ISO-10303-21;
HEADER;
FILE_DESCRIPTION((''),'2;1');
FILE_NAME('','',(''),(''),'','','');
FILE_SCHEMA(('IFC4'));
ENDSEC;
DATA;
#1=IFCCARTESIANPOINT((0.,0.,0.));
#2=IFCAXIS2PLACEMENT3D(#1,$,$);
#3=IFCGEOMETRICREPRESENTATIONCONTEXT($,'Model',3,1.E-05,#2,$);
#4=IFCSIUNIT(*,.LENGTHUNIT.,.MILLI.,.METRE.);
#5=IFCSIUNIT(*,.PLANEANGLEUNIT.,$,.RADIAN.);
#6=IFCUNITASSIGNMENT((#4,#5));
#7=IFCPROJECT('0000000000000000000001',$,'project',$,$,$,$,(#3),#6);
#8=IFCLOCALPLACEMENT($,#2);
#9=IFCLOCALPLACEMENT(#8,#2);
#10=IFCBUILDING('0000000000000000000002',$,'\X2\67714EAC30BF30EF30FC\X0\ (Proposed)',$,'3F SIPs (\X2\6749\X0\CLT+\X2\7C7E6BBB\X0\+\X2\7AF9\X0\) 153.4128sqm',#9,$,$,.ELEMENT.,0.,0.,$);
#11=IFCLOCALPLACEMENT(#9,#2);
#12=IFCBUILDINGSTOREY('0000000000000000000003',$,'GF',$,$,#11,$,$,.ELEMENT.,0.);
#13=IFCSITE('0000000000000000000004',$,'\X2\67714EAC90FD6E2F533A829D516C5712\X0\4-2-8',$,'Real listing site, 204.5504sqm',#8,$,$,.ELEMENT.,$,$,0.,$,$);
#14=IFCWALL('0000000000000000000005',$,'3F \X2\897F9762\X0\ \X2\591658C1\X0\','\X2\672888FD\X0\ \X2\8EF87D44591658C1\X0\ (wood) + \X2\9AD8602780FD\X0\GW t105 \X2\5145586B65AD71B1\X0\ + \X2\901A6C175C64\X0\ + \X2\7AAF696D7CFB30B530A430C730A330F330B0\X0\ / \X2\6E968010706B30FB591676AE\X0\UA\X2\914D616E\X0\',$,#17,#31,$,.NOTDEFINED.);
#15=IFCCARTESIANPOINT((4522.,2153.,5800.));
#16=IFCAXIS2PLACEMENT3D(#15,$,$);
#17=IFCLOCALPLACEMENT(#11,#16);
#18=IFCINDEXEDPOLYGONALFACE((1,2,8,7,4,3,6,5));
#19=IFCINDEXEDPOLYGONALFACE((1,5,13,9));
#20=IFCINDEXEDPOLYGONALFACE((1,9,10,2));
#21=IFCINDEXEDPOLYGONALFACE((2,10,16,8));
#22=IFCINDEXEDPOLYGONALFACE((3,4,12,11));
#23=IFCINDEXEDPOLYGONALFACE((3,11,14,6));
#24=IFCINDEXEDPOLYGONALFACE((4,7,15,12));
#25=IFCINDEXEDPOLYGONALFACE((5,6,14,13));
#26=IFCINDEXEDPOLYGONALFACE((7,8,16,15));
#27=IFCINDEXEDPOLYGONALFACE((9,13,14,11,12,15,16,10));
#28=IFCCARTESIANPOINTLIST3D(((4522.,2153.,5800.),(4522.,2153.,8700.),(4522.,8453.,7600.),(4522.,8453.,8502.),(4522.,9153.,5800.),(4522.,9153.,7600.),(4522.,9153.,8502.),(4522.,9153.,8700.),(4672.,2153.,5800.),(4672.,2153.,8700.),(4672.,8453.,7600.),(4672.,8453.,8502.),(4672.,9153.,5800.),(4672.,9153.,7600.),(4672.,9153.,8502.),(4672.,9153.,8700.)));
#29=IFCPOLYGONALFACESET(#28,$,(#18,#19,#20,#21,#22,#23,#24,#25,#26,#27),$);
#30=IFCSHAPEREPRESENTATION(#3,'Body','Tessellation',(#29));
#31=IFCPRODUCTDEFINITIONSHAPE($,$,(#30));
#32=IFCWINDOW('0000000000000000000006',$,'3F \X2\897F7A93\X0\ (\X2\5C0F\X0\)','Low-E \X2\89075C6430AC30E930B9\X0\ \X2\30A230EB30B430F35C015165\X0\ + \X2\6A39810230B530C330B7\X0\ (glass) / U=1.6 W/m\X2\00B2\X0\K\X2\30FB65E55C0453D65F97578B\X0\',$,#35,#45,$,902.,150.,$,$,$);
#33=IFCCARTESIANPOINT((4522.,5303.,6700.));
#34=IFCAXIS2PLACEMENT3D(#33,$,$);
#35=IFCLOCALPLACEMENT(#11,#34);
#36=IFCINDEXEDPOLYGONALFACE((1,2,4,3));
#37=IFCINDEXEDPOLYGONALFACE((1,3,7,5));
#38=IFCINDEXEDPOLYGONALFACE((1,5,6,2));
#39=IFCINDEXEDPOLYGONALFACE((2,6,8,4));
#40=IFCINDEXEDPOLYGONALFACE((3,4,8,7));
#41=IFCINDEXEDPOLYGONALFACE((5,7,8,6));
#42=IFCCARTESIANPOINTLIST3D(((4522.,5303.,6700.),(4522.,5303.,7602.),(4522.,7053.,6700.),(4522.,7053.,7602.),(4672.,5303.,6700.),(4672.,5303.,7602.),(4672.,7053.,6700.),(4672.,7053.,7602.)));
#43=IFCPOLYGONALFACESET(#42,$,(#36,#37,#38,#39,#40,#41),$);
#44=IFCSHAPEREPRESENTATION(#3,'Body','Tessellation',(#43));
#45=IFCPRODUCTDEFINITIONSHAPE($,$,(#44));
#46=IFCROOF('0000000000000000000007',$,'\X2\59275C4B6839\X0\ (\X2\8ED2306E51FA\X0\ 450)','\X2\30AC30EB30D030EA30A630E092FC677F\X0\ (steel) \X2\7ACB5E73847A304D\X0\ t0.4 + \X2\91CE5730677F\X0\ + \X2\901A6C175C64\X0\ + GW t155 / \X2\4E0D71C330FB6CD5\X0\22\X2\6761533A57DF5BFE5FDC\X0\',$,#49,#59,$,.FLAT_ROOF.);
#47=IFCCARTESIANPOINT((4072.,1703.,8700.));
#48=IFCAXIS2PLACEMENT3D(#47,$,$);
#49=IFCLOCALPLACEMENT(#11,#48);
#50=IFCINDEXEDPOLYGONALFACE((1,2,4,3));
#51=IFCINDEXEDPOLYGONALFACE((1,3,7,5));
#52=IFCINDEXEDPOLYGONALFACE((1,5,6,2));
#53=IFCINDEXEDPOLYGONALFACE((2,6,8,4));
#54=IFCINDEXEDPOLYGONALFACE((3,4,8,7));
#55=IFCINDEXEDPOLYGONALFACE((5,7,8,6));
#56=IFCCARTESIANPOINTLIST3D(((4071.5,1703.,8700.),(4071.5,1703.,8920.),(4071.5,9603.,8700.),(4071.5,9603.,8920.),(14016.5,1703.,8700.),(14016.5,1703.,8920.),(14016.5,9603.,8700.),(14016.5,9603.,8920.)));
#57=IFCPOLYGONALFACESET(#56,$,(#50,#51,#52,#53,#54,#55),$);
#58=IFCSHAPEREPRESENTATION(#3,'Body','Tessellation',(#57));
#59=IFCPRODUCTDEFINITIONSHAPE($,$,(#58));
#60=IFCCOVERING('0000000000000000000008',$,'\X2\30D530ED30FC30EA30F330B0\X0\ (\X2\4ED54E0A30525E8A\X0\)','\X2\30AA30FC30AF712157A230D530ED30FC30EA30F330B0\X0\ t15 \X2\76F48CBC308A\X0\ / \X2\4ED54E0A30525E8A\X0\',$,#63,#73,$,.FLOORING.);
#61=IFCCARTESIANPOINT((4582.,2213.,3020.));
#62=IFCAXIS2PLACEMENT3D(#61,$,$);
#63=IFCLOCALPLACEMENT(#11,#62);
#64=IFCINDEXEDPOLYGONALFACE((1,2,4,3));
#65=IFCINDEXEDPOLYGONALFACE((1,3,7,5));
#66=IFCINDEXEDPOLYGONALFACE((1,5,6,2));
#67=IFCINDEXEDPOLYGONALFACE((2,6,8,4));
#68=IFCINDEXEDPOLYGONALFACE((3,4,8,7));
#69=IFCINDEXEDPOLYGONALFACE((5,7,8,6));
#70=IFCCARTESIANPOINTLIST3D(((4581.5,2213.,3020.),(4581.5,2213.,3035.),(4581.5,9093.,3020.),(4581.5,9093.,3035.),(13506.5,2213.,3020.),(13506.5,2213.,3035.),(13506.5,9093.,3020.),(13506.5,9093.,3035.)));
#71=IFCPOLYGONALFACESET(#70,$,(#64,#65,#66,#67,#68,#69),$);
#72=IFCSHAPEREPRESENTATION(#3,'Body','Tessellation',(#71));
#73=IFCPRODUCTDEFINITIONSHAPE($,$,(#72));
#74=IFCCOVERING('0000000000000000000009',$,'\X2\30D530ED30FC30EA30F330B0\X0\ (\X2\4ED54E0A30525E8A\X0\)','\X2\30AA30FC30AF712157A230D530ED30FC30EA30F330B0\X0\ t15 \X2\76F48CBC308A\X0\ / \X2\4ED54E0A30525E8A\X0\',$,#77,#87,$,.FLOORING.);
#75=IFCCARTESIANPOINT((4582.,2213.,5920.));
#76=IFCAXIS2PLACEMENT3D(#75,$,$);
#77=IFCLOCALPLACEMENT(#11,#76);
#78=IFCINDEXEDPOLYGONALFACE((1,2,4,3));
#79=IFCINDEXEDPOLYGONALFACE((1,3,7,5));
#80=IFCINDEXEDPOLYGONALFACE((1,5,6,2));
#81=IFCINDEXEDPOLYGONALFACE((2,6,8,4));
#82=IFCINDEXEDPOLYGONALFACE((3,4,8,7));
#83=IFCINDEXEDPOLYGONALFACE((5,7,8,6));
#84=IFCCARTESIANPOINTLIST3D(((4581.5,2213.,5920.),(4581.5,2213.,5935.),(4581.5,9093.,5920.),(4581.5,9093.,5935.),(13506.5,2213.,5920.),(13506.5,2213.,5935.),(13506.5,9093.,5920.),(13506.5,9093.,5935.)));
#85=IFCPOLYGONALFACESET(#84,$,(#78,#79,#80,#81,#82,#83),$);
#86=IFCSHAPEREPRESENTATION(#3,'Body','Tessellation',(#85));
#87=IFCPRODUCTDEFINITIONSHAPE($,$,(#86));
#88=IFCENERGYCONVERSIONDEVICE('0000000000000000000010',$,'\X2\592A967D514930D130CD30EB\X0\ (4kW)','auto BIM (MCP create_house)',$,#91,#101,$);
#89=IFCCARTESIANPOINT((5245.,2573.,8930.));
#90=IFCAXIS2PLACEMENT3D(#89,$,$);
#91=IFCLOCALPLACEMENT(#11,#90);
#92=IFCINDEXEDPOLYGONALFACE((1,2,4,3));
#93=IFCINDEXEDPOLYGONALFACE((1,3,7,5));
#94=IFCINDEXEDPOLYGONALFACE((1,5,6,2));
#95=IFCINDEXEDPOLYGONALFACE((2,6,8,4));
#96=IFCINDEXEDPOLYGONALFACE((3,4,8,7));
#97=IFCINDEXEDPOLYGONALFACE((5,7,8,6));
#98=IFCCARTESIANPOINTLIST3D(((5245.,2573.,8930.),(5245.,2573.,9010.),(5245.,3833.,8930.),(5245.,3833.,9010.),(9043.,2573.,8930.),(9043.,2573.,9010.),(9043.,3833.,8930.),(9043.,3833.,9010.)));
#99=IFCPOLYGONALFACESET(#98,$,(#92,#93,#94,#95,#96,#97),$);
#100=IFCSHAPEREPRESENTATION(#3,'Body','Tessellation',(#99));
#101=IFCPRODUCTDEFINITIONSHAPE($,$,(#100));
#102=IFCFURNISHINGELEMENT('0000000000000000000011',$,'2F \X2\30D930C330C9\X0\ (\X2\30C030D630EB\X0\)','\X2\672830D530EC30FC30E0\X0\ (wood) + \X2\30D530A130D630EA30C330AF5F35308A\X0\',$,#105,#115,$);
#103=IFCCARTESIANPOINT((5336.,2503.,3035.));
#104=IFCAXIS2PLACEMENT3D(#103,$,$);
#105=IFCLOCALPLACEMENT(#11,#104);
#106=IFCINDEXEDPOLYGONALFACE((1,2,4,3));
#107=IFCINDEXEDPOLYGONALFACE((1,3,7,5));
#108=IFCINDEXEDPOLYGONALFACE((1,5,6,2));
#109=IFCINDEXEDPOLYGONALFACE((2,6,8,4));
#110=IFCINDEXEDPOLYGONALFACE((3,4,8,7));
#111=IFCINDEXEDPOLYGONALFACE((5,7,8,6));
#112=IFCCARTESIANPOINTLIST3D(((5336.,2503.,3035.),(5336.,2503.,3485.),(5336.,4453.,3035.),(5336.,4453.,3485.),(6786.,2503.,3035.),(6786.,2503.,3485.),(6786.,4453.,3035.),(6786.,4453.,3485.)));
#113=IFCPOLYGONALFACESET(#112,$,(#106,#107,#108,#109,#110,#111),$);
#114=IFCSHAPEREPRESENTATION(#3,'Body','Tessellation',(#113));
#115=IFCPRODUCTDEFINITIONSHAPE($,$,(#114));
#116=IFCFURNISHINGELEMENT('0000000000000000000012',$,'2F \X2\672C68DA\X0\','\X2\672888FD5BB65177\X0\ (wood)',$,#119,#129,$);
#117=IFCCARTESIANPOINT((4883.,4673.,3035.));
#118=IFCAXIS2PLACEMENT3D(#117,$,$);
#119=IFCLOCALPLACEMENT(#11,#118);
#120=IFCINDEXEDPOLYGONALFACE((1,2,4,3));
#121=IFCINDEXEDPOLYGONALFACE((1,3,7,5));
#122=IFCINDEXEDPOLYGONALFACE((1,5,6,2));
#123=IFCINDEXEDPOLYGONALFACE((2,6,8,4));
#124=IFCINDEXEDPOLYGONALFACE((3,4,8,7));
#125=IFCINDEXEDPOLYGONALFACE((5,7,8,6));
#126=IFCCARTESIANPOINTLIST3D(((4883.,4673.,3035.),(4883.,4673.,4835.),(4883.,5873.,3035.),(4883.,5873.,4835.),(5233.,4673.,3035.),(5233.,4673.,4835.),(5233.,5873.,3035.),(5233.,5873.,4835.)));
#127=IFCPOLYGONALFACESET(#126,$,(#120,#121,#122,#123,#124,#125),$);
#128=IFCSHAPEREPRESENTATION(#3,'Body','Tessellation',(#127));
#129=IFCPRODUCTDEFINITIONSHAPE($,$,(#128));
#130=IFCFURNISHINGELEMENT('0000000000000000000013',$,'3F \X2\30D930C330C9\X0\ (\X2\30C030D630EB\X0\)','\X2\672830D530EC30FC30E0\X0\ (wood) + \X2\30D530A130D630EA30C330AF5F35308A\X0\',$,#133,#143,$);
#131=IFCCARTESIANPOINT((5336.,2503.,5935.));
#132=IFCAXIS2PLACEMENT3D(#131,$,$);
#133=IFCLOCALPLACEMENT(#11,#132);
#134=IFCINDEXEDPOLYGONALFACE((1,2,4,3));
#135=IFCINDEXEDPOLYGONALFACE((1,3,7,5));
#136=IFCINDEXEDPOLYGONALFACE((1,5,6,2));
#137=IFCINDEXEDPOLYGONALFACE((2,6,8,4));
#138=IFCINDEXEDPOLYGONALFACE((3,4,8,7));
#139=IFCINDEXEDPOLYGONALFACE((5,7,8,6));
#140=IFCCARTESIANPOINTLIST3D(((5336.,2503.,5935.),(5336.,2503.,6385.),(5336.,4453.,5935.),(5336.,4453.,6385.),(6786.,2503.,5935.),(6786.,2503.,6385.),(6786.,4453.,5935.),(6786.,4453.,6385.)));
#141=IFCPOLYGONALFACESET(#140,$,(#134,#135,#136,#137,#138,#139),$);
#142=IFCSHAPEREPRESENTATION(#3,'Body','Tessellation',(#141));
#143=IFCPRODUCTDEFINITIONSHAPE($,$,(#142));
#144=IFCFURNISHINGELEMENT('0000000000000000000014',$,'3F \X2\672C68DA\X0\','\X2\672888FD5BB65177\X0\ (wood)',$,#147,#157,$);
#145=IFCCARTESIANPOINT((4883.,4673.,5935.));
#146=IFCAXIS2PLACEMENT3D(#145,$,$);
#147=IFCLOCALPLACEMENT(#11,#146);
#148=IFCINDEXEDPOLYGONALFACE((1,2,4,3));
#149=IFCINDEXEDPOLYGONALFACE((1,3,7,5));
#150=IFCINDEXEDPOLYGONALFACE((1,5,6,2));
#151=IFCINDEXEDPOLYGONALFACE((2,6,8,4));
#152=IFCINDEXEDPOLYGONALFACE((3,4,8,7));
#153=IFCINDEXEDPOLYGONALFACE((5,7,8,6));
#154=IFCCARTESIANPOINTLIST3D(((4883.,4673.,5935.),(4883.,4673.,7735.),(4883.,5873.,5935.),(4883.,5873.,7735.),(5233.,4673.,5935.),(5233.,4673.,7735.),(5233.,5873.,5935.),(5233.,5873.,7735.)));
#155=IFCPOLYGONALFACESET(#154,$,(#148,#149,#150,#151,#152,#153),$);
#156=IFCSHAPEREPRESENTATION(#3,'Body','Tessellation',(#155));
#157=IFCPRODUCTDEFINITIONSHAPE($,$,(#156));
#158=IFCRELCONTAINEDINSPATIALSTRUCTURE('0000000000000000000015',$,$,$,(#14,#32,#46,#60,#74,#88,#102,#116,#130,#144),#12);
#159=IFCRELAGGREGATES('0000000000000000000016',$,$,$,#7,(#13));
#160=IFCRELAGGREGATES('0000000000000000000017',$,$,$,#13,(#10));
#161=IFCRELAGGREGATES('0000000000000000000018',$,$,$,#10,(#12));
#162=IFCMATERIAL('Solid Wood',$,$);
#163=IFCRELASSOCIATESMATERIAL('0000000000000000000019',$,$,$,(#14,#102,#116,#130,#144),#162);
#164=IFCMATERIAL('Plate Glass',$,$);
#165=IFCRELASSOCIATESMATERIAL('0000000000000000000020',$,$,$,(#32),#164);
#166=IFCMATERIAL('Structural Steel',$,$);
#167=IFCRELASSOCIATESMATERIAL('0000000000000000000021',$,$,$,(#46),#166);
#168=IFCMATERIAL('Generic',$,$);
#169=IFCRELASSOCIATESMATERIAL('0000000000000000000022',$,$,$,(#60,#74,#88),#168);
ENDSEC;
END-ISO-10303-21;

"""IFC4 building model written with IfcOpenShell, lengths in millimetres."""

from ifc_helpers import new_model, si_unit, frame, frame_2d, origin, place, context, project, spatial, rectangle, extrude, material, element, fill, save


model = new_model("IFC4")

# Units and contexts
model_context = context("Model", 3, precision=1e-05, world=origin())
ifc_project = project(units=[si_unit("LENGTHUNIT", "METRE", prefix="MILLI"), si_unit("PLANEANGLEUNIT", "RADIAN")], contexts=[model_context])

# Site, building, storey
site_placement = place(None, origin())
site = spatial("IfcSite", under=ifc_project, at=site_placement, Name="東京都港区芝公園4-2-8", ObjectType="Real listing site, 204.5504sqm", CompositionType="ELEMENT", RefElevation=0.0)
building_placement = place(site_placement, origin())
building = spatial("IfcBuilding", under=site, at=building_placement, Name="東京タワー (Proposed)", ObjectType="3F SIPs (杉CLT+籾殻+竹) 153.4128sqm", CompositionType="ELEMENT", ElevationOfRefHeight=0.0, ElevationOfTerrain=0.0)
storey_placement = place(building_placement, origin())
storey = spatial("IfcBuildingStorey", under=building, at=storey_placement, Name="GF", CompositionType="ELEMENT", Elevation=0.0)

# Shared definitions
ifc_material_1 = material(Name="Solid Wood")

# Shared definitions
ifc_material_2 = material(Name="Plate Glass")

# Wall, opening, window
wall_1_placement = place(storey_placement, frame((4522.0, 2153.0, 5800.0)))
wall_1 = element("IfcWall", 1, at=wall_1_placement, inside=storey, material=ifc_material_1, Name="3F 西面 外壁", Description="木製 軸組外壁 (wood) + 高性能GW t105 充填断熱 + 通気層 + 窯業系サイディング / 準耐火・外皮UA配慮", PredefinedType="NOTDEFINED", context=model_context, shape_type="SweptSolid", body=[
    extrude(rectangle(XDim=150.0, YDim=7000.0, at=frame_2d((75.0, 3500.0))), frame((4522.0, 2153.0, 5800.0)), (0.0, 0.0, 1.0), 2900.0),
])
opening_1_placement = place(storey_placement, frame((4522.0, 5303.0, 6700.0)))
opening_1 = element("IfcOpeningElement", 2, at=opening_1_placement, cuts=wall_1, PredefinedType="NOTDEFINED", context=model_context, shape_type="SweptSolid", body=[
    extrude(rectangle(XDim=150.0, YDim=1750.0, at=frame_2d((75.0, 875.0))), frame((4522.0, 5303.0, 6700.0)), (0.0, 0.0, 1.0), 902.0),
])
window_1_placement = place(storey_placement, frame((4522.0, 5303.0, 6700.0)))
window_1 = element("IfcWindow", 3, at=window_1_placement, inside=storey, material=ifc_material_2, Name="3F 西窓 (小)", Description="Low-E 複層ガラス アルゴン封入 + 樹脂サッシ (glass) / U=1.6 W/m²K・日射取得型", OverallHeight=902.0, OverallWidth=150.0, context=model_context, shape_type="SweptSolid", body=[
    extrude(rectangle(XDim=150.0, YDim=1750.0, at=frame_2d((75.0, 875.0))), frame((4522.0, 5303.0, 6700.0)), (0.0, 0.0, 1.0), 902.0),
])
fill(opening_1, window_1)

# Roof
ifc_material_3 = material(Name="Structural Steel")
roof_placement = place(storey_placement, frame((4072.0, 1703.0, 8700.0)))
element("IfcRoof", 4, at=roof_placement, inside=storey, material=ifc_material_3, Name="大屋根 (軒の出 450)", Description="ガルバリウム鋼板 (steel) 立平葺き t0.4 + 野地板 + 通気層 + GW t155 / 不燃・法22条区域対応", PredefinedType="FLAT_ROOF", context=model_context, shape_type="SweptSolid", body=[
    extrude(rectangle(XDim=9945.0, YDim=7900.0, at=frame_2d((4972.0, 3950.0))), frame((4072.0, 1703.0, 8700.0)), (0.0, 0.0, 1.0), 220.0),
])

# Coverings
ifc_material_4 = material(Name="Generic")
covering_1_placement = place(storey_placement, frame((4582.0, 2213.0, 3020.0)))
element("IfcCovering", 5, at=covering_1_placement, inside=storey, material=ifc_material_4, Name="フローリング (仕上げ床)", Description="オーク無垢フローリング t15 直貼り / 仕上げ床", PredefinedType="FLOORING", context=model_context, shape_type="SweptSolid", body=[
    extrude(rectangle(XDim=8925.0, YDim=6880.0, at=frame_2d((4462.0, 3440.0))), frame((4582.0, 2213.0, 3020.0)), (0.0, 0.0, 1.0), 15.0),
])
covering_2_placement = place(storey_placement, frame((4582.0, 2213.0, 5920.0)))
element("IfcCovering", 6, at=covering_2_placement, inside=storey, material=ifc_material_4, Name="フローリング (仕上げ床)", Description="オーク無垢フローリング t15 直貼り / 仕上げ床", PredefinedType="FLOORING", context=model_context, shape_type="SweptSolid", body=[
    extrude(rectangle(XDim=8925.0, YDim=6880.0, at=frame_2d((4462.0, 3440.0))), frame((4582.0, 2213.0, 5920.0)), (0.0, 0.0, 1.0), 15.0),
])

# Energy conversion device
energy_conversion_device_placement = place(storey_placement, frame((5245.0, 2573.0, 8930.0)))
element("IfcEnergyConversionDevice", 7, at=energy_conversion_device_placement, inside=storey, material=ifc_material_4, Name="太陽光パネル (4kW)", Description="auto BIM (MCP create_house)", context=model_context, shape_type="SweptSolid", body=[
    extrude(rectangle(XDim=3798.0, YDim=1260.0, at=frame_2d((1899.0, 630.0))), frame((5245.0, 2573.0, 8930.0)), (0.0, 0.0, 1.0), 80.0),
])

# Furnishing elements
furnishing_1_placement = place(storey_placement, frame((5336.0, 2503.0, 3035.0)))
element("IfcFurnishingElement", 8, at=furnishing_1_placement, inside=storey, material=ifc_material_1, Name="2F ベッド (ダブル)", Description="木フレーム (wood) + ファブリック張り", context=model_context, shape_type="SweptSolid", body=[
    extrude(rectangle(XDim=1450.0, YDim=1950.0, at=frame_2d((725.0, 975.0))), frame((5336.0, 2503.0, 3035.0)), (0.0, 0.0, 1.0), 450.0),
])
furnishing_2_placement = place(storey_placement, frame((4883.0, 4673.0, 3035.0)))
element("IfcFurnishingElement", 9, at=furnishing_2_placement, inside=storey, material=ifc_material_1, Name="2F 本棚", Description="木製家具 (wood)", context=model_context, shape_type="SweptSolid", body=[
    extrude(rectangle(XDim=350.0, YDim=1200.0, at=frame_2d((175.0, 600.0))), frame((4883.0, 4673.0, 3035.0)), (0.0, 0.0, 1.0), 1800.0),
])
furnishing_3_placement = place(storey_placement, frame((5336.0, 2503.0, 5935.0)))
element("IfcFurnishingElement", 10, at=furnishing_3_placement, inside=storey, material=ifc_material_1, Name="3F ベッド (ダブル)", Description="木フレーム (wood) + ファブリック張り", context=model_context, shape_type="SweptSolid", body=[
    extrude(rectangle(XDim=1450.0, YDim=1950.0, at=frame_2d((725.0, 975.0))), frame((5336.0, 2503.0, 5935.0)), (0.0, 0.0, 1.0), 450.0),
])
furnishing_4_placement = place(storey_placement, frame((4883.0, 4673.0, 5935.0)))
element("IfcFurnishingElement", 11, at=furnishing_4_placement, inside=storey, material=ifc_material_1, Name="3F 本棚", Description="木製家具 (wood)", context=model_context, shape_type="SweptSolid", body=[
    extrude(rectangle(XDim=350.0, YDim=1200.0, at=frame_2d((175.0, 600.0))), frame((4883.0, 4673.0, 5935.0)), (0.0, 0.0, 1.0), 1800.0),
])

save(model, "model.ifc")
